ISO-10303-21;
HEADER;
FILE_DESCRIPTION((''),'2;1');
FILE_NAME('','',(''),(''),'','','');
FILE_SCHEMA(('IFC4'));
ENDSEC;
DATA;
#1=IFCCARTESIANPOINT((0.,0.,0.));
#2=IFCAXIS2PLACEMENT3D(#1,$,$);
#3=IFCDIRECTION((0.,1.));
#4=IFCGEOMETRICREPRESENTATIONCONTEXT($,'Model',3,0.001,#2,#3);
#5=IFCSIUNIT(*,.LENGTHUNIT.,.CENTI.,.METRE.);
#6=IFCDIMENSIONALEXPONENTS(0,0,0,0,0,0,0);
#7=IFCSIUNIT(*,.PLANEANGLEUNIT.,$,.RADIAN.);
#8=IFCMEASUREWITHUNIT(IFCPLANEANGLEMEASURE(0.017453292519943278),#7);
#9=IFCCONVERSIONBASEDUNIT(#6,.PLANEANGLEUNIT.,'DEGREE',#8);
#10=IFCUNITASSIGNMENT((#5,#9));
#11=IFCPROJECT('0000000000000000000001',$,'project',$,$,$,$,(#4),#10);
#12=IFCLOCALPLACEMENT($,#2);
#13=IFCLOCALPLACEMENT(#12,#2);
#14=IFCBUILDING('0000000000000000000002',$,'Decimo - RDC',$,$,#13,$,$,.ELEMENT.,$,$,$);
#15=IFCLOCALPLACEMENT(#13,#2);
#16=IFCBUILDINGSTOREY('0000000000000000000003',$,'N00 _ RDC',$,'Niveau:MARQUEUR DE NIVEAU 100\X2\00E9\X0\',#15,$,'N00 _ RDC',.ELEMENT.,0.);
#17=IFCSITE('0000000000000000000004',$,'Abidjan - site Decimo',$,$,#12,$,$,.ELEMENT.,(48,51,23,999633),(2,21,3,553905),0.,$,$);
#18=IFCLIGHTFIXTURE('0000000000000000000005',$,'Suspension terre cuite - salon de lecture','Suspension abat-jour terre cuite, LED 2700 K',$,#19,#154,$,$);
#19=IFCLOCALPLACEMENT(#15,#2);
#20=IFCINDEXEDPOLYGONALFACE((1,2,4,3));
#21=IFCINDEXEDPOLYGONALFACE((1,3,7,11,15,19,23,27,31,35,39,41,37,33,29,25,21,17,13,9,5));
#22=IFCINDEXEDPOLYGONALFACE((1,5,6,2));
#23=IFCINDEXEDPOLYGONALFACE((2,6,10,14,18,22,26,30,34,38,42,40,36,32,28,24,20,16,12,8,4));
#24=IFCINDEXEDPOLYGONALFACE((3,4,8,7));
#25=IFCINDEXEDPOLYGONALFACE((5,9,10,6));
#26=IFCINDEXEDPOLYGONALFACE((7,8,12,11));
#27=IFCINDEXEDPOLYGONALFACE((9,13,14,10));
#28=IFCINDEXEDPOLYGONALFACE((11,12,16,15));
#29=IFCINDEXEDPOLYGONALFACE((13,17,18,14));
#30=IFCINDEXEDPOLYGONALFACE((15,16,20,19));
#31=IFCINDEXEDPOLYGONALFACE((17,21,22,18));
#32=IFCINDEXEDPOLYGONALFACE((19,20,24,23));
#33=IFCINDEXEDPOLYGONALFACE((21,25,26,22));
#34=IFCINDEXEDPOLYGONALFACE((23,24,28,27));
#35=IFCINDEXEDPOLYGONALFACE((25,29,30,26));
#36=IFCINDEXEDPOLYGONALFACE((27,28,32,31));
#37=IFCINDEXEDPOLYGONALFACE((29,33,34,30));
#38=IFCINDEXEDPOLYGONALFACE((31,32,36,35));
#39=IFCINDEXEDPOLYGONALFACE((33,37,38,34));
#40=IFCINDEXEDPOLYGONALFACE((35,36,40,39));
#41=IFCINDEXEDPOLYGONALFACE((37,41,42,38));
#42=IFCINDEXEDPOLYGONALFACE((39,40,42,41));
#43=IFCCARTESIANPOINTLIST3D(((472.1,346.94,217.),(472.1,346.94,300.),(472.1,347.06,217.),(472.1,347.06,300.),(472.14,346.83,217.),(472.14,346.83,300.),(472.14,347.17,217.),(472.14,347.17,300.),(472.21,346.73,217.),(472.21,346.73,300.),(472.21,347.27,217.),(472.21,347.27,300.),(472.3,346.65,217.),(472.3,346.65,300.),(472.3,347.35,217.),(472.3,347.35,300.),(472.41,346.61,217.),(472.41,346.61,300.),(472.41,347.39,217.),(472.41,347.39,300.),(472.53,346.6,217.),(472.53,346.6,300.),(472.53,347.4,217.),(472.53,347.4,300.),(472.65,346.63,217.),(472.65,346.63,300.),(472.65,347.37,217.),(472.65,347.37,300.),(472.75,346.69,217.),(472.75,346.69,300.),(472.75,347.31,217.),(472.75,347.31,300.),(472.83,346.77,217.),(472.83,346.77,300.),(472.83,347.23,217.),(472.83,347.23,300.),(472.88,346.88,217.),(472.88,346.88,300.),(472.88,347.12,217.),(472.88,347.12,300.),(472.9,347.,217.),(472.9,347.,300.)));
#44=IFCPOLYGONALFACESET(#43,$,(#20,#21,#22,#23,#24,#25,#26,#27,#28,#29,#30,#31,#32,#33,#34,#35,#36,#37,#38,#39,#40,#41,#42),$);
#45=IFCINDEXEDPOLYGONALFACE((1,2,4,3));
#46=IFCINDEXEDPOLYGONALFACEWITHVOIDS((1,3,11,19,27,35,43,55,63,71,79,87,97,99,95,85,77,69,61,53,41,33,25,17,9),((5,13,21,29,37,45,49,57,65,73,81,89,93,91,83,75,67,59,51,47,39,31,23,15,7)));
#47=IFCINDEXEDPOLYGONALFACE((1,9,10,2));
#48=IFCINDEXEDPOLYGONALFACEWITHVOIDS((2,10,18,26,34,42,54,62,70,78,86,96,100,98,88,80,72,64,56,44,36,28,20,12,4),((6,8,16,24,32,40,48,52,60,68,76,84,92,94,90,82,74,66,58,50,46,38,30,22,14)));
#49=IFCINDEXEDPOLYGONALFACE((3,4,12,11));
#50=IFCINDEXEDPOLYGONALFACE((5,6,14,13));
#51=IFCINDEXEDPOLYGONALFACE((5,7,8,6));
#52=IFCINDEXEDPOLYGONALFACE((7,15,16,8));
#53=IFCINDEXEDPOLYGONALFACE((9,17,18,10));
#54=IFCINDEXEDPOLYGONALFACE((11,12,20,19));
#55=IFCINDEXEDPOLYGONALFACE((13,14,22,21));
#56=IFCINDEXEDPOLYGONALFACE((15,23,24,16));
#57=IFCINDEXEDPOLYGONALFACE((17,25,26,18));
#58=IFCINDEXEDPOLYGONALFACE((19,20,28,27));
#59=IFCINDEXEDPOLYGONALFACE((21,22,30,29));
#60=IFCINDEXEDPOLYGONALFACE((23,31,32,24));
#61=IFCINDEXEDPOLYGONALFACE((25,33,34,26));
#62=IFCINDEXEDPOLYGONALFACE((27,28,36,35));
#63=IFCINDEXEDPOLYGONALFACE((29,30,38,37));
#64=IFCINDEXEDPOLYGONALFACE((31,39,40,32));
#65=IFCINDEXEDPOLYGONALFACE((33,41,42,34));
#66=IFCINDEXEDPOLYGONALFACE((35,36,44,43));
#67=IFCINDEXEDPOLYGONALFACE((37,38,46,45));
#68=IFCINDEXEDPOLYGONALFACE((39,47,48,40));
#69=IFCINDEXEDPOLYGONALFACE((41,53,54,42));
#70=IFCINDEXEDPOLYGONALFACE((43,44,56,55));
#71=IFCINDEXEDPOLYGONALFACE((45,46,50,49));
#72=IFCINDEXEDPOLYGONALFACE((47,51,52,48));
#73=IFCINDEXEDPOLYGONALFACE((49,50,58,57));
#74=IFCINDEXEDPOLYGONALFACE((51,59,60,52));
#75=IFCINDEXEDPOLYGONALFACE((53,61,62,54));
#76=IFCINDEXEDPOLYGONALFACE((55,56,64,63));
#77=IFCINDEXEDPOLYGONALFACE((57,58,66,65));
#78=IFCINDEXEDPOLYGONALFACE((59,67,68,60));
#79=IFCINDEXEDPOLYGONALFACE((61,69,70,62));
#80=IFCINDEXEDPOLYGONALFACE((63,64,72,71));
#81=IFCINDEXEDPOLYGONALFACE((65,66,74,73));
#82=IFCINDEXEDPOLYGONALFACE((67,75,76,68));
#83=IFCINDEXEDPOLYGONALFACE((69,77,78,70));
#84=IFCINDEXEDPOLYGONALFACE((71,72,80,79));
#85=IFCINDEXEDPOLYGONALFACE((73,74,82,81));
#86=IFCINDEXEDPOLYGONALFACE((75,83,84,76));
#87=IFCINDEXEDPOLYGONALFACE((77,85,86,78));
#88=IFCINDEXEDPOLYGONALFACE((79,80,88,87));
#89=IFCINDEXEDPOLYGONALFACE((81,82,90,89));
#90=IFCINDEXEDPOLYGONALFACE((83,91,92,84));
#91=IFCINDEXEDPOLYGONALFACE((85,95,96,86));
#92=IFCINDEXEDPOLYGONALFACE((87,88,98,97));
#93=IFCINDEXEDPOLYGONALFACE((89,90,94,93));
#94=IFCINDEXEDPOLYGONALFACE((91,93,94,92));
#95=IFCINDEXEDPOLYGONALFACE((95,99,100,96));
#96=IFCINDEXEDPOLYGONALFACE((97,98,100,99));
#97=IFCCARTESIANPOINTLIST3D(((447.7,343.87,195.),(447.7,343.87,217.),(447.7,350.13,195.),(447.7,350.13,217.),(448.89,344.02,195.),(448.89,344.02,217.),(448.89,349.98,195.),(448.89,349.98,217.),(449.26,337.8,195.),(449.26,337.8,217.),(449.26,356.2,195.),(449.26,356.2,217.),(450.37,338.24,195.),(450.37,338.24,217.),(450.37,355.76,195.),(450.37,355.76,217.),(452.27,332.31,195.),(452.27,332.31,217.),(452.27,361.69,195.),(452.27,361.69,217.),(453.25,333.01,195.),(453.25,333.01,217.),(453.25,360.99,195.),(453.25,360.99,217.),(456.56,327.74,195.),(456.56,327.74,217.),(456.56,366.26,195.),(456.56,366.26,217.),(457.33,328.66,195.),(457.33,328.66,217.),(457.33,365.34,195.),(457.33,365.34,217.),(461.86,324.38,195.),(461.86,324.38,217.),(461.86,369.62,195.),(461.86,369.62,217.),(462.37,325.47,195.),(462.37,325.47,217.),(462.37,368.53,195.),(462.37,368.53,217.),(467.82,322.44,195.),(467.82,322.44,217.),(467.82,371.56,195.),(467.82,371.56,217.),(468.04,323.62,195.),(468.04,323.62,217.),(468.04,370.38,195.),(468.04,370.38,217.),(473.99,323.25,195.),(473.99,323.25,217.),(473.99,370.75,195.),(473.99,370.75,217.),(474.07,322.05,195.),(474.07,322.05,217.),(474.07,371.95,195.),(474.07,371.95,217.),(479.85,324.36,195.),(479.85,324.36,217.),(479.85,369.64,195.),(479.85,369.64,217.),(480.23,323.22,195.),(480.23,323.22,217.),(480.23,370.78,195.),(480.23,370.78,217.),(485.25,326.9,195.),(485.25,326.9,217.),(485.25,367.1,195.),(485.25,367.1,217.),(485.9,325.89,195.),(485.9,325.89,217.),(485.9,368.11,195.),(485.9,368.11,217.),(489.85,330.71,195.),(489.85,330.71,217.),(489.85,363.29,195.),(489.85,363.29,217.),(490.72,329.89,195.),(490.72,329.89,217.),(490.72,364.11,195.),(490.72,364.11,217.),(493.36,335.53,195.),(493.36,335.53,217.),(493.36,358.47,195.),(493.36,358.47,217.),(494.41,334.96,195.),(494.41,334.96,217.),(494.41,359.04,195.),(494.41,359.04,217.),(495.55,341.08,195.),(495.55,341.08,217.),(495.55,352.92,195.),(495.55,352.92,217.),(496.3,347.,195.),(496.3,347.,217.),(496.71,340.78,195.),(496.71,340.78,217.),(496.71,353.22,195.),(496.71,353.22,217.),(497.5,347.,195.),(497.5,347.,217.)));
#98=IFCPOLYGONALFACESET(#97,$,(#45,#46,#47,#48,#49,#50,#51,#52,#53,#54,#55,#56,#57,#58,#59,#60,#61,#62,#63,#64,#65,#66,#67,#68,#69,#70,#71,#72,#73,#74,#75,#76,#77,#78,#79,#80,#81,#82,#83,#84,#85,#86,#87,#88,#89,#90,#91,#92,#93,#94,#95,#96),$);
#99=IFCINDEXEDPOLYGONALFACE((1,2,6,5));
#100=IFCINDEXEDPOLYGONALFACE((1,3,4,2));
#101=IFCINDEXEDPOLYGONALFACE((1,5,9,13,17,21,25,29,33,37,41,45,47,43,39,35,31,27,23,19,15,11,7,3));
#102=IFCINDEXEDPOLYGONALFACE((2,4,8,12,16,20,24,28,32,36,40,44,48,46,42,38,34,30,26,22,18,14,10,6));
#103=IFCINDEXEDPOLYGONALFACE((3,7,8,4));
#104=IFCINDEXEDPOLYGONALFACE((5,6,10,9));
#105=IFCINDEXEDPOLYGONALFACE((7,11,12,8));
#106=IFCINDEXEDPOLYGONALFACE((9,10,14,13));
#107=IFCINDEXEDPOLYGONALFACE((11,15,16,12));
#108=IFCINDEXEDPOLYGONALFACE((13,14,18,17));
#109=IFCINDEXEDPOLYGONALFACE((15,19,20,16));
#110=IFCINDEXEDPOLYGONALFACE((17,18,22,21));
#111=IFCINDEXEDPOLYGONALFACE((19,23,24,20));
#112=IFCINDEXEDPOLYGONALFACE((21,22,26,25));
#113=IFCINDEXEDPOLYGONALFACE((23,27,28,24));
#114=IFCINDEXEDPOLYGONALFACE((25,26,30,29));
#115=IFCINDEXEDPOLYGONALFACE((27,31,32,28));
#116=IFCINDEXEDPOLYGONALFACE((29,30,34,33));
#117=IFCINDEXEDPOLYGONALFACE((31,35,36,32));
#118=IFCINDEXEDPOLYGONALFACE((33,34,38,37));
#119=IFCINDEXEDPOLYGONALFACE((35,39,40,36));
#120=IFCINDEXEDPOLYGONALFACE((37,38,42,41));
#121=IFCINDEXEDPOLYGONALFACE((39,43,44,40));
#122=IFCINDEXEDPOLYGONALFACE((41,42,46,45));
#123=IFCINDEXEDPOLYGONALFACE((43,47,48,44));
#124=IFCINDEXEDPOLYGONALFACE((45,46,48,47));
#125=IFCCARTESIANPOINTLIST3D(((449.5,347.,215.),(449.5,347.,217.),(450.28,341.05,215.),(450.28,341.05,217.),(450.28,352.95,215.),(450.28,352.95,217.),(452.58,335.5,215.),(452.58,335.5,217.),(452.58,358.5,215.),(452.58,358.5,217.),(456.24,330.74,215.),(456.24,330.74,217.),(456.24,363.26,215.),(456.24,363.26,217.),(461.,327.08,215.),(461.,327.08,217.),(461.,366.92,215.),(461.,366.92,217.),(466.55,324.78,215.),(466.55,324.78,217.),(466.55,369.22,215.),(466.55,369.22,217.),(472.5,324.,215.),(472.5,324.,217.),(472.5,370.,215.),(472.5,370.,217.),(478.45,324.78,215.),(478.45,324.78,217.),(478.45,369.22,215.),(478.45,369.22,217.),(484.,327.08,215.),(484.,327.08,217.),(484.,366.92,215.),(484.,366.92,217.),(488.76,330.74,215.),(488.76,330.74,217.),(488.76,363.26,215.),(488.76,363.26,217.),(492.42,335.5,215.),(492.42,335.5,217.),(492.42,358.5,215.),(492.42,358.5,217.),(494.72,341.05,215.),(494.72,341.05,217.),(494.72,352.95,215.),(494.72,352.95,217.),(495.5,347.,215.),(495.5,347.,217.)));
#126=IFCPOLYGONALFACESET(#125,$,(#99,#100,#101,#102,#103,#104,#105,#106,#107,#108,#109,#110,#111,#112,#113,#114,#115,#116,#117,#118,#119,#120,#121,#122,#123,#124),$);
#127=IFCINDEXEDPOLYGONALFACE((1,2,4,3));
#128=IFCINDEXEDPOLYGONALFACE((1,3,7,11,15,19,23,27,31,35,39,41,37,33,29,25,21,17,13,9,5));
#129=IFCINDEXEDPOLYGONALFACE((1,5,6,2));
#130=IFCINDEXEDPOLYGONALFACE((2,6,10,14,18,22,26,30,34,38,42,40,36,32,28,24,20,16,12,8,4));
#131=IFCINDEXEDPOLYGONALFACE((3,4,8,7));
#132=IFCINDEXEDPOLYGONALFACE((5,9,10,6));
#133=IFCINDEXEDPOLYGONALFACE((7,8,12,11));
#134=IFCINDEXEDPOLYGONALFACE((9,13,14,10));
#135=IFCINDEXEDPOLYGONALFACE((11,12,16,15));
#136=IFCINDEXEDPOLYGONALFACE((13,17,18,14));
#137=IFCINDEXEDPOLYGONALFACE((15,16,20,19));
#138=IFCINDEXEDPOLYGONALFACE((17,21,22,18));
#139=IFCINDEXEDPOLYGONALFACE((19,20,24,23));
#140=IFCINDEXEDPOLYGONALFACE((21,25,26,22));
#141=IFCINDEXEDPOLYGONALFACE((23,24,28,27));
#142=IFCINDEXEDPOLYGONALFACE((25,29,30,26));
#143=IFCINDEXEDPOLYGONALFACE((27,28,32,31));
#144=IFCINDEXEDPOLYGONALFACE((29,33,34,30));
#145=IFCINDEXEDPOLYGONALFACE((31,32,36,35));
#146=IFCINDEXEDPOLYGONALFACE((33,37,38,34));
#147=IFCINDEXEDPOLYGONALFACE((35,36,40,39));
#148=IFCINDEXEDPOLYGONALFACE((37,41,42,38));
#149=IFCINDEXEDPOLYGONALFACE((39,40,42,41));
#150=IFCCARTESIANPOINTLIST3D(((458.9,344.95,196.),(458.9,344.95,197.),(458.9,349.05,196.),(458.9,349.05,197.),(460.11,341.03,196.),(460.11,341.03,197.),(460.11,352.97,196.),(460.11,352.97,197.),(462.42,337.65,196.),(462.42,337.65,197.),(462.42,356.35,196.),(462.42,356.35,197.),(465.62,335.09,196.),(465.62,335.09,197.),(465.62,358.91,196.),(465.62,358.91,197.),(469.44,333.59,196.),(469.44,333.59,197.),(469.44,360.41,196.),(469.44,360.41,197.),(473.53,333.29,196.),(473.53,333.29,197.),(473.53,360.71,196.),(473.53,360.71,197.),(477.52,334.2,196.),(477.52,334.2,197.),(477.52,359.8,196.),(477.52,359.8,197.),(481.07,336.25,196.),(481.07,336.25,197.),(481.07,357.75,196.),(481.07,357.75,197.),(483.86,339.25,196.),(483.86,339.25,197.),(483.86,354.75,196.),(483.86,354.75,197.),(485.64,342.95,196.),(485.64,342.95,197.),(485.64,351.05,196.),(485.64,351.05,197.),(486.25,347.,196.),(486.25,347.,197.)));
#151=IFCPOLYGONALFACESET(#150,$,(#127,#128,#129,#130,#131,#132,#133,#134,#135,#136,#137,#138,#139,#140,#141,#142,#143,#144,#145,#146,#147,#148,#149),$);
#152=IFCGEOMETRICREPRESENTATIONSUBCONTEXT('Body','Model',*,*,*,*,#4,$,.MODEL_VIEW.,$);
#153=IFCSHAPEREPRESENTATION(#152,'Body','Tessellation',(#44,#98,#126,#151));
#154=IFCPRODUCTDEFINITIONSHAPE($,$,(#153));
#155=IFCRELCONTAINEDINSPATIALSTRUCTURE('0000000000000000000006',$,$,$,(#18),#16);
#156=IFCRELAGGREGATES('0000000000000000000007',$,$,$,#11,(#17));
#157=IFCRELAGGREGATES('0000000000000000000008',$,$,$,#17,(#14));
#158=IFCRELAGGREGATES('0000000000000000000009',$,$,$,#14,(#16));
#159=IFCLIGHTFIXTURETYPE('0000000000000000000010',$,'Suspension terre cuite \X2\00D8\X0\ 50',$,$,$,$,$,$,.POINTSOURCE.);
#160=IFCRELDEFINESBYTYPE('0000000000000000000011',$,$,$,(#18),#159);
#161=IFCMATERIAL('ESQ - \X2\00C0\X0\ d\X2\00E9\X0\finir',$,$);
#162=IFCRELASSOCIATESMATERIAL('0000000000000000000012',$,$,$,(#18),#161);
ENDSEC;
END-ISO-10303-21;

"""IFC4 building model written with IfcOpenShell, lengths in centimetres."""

from ifc_helpers import new_model, entity, si_unit, converted_unit, direction, frame, frame_2d, origin, origin_with_axes, place, context, subcontext, project, spatial, circle, hollow_circle, extrude, material, type_object, element, save


model = new_model("IFC4")

# Units and contexts
model_context = context("Model", 3, precision=0.001, world=origin(), true_north=direction((0.0, 1.0)))
body_context = subcontext(model_context, "Body", "Model", "MODEL_VIEW")
ifc_project = project(units=[si_unit("LENGTHUNIT", "METRE", prefix="CENTI"), converted_unit("PLANEANGLEUNIT", "DEGREE", entity("IfcPlaneAngleMeasure", 0.017453292519943278), si_unit("PLANEANGLEUNIT", "RADIAN"), dimensions=[0, 0, 0, 0, 0, 0, 0])], contexts=[model_context])

# Site, building, storey
site_placement = place(None, origin())
site = spatial("IfcSite", under=ifc_project, at=site_placement, Name="Abidjan - site Decimo", CompositionType="ELEMENT", RefLatitude=(48, 51, 23, 999633), RefLongitude=(2, 21, 3, 553905), RefElevation=0.0)
building_placement = place(site_placement, origin())
building = spatial("IfcBuilding", under=site, at=building_placement, Name="Decimo - RDC", CompositionType="ELEMENT")
storey_placement = place(building_placement, origin())
storey = spatial("IfcBuildingStorey", under=building, at=storey_placement, Name="N00 _ RDC", ObjectType="Niveau:MARQUEUR DE NIVEAU 100é", LongName="N00 _ RDC", CompositionType="ELEMENT", Elevation=0.0)

# Light fixture
ifc_material_1 = material(Name="ESQ - À définir")
light_fixture_type_1 = type_object("IfcLightFixtureType", Name="Suspension terre cuite Ø 50", PredefinedType="POINTSOURCE")
light_fixture_1_placement = place(storey_placement, origin_with_axes())
element("IfcLightFixture", 1, at=light_fixture_1_placement, inside=storey, type_object=light_fixture_type_1, material=ifc_material_1, Name="Suspension terre cuite - salon de lecture", Description="Suspension abat-jour terre cuite, LED 2700 K", context=body_context, shape_type="SweptSolid", body=[
    extrude(circle(Radius=0.4, at=frame_2d((472.5, 347.0))), frame((0.0, 0.0, 217.0)), (0.0, 0.0, 1.0), 83.0),
    extrude(hollow_circle(Radius=25.0, WallThickness=1.2, at=frame_2d((472.5, 347.0))), frame((0.0, 0.0, 195.0)), (0.0, 0.0, 1.0), 22.0),
    extrude(circle(Radius=23.0, at=frame_2d((472.5, 347.0))), frame((0.0, 0.0, 215.0)), (0.0, 0.0, 1.0), 2.0),
    extrude(circle(Radius=13.75, at=frame_2d((472.5, 347.0))), frame((0.0, 0.0, 196.0)), (0.0, 0.0, 1.0), 1.0),
])

save(model, "model.ifc")
